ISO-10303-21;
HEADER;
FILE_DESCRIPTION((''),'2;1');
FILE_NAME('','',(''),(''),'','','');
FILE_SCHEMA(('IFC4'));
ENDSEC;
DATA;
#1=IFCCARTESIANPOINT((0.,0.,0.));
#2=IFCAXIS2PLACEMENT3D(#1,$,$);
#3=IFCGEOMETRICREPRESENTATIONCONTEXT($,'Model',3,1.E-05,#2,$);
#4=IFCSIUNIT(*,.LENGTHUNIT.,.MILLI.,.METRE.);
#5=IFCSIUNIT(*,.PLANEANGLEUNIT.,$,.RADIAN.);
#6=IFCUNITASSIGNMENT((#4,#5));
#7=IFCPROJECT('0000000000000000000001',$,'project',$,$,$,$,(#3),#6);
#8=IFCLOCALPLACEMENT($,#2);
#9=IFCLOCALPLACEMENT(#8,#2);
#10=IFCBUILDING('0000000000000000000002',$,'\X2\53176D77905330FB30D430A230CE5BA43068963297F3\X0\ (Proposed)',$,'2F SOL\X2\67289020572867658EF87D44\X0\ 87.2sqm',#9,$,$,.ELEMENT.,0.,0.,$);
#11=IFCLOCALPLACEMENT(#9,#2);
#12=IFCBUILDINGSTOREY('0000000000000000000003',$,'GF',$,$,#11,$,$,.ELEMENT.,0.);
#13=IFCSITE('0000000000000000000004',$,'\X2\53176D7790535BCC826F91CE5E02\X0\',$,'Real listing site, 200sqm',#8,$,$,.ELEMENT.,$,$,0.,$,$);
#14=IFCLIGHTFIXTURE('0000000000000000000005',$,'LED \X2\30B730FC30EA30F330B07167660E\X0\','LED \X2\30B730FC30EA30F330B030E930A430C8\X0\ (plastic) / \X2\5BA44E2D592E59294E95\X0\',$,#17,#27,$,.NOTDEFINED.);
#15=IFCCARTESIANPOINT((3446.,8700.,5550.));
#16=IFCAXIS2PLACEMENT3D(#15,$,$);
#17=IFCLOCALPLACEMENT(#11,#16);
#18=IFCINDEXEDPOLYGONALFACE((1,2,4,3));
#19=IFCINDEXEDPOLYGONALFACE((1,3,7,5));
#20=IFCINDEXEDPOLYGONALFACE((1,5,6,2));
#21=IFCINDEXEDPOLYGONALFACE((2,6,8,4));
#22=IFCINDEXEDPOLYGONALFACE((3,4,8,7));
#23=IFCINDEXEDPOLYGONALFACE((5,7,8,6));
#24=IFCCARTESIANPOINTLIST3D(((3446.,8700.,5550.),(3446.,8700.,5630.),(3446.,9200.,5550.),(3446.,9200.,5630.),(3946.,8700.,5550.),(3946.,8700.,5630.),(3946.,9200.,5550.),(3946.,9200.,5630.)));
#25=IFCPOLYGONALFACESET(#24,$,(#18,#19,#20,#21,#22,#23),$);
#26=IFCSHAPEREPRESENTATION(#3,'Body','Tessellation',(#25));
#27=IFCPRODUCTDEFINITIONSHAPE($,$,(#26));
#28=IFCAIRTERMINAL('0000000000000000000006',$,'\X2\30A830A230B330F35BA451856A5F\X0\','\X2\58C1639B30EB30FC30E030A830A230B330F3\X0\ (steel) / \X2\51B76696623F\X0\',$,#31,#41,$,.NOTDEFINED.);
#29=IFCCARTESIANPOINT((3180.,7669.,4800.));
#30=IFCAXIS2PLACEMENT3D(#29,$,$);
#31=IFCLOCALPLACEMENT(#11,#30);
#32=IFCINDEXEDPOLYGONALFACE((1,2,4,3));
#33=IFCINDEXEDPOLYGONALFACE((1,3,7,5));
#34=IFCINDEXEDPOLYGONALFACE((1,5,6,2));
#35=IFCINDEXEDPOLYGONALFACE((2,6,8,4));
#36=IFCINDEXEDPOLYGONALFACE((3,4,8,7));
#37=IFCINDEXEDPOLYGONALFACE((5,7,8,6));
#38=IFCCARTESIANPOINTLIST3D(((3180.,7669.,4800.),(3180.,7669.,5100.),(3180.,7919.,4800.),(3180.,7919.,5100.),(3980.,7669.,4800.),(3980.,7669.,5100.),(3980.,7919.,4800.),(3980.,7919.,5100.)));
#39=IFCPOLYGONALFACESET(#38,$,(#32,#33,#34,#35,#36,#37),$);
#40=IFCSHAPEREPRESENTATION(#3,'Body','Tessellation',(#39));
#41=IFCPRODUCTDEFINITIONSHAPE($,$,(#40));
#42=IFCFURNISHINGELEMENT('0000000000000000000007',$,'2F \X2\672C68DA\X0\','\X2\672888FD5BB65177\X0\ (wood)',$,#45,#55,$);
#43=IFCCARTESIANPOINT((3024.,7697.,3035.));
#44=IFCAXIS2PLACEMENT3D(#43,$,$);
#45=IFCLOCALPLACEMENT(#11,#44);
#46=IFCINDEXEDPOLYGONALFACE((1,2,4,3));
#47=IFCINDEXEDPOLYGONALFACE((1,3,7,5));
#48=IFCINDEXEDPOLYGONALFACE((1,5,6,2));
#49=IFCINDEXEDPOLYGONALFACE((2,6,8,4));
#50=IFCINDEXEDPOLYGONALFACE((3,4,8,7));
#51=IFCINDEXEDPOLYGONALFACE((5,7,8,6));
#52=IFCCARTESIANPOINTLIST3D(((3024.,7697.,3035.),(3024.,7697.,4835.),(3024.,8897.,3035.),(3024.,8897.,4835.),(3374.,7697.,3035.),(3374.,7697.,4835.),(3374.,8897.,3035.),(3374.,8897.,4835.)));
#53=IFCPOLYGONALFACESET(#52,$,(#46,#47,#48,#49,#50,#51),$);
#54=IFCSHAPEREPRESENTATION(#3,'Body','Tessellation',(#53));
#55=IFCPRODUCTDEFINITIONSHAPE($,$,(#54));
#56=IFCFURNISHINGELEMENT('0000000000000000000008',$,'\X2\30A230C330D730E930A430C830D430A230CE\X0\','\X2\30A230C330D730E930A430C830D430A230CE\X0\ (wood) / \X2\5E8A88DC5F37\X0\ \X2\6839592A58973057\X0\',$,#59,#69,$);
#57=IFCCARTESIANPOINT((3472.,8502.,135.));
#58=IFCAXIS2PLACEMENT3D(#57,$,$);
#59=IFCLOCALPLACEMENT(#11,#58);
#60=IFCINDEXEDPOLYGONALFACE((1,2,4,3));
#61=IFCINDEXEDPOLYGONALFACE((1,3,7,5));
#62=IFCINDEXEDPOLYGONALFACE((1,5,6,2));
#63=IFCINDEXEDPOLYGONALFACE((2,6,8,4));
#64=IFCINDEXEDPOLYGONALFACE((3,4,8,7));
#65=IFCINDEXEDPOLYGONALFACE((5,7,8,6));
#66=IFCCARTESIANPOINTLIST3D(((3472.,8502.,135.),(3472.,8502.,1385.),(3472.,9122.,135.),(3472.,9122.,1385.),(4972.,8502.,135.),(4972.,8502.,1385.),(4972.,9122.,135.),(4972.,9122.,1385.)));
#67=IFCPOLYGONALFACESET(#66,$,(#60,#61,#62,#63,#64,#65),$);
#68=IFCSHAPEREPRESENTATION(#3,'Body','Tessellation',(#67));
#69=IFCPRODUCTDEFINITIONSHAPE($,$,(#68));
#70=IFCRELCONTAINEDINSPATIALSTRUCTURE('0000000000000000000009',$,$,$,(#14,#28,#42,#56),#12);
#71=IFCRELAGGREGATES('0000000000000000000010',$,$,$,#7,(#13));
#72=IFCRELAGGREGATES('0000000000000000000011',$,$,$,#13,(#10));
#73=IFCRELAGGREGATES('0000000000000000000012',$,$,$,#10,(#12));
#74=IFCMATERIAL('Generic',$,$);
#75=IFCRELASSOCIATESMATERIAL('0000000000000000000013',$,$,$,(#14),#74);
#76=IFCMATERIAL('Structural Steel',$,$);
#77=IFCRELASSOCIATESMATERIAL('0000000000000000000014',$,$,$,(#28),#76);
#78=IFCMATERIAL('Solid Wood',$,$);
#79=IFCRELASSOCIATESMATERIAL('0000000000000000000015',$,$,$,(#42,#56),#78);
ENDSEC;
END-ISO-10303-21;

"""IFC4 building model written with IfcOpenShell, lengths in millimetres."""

from ifc_helpers import new_model, si_unit, frame, frame_2d, origin, place, context, project, spatial, rectangle, extrude, material, element, save


model = new_model("IFC4")

# Units and contexts
model_context = context("Model", 3, precision=1e-05, world=origin())
ifc_project = project(units=[si_unit("LENGTHUNIT", "METRE", prefix="MILLI"), si_unit("PLANEANGLEUNIT", "RADIAN")], contexts=[model_context])

# Site, building, storey
site_placement = place(None, origin())
site = spatial("IfcSite", under=ifc_project, at=site_placement, Name="北海道富良野市", ObjectType="Real listing site, 200sqm", CompositionType="ELEMENT", RefElevation=0.0)
building_placement = place(site_placement, origin())
building = spatial("IfcBuilding", under=site, at=building_placement, Name="北海道・ピアノ室と防音 (Proposed)", ObjectType="2F SOL木造在来軸組 87.2sqm", CompositionType="ELEMENT", ElevationOfRefHeight=0.0, ElevationOfTerrain=0.0)
storey_placement = place(building_placement, origin())
storey = spatial("IfcBuildingStorey", under=building, at=storey_placement, Name="GF", CompositionType="ELEMENT", Elevation=0.0)

# Shared definitions
ifc_material_1 = material(Name="Solid Wood")

# Shared definitions
ifc_material_2 = material(Name="Structural Steel")

# Shared definitions
ifc_material_3 = material(Name="Generic")

# Light fixture
light_fixture_1_placement = place(storey_placement, frame((3446.0, 8700.0, 5550.0)))
element("IfcLightFixture", 1, at=light_fixture_1_placement, inside=storey, material=ifc_material_3, Name="LED シーリング照明", Description="LED シーリングライト (plastic) / 室中央天井", PredefinedType="NOTDEFINED", context=model_context, shape_type="SweptSolid", body=[
    extrude(rectangle(XDim=500.0, YDim=500.0, at=frame_2d((250.0, 250.0))), frame((3446.0, 8700.0, 5550.0)), (0.0, 0.0, 1.0), 80.0),
])

# Air terminal
air_terminal_placement = place(storey_placement, frame((3180.0, 7669.0, 4800.0)))
element("IfcAirTerminal", 2, at=air_terminal_placement, inside=storey, material=ifc_material_2, Name="エアコン室内機", Description="壁掛ルームエアコン (steel) / 冷暖房", PredefinedType="NOTDEFINED", context=model_context, shape_type="SweptSolid", body=[
    extrude(rectangle(XDim=800.0, YDim=250.0, at=frame_2d((400.0, 125.0))), frame((3180.0, 7669.0, 4800.0)), (0.0, 0.0, 1.0), 300.0),
])

# Furnishing elements
furnishing_1_placement = place(storey_placement, frame((3024.0, 7697.0, 3035.0)))
element("IfcFurnishingElement", 3, at=furnishing_1_placement, inside=storey, material=ifc_material_1, Name="2F 本棚", Description="木製家具 (wood)", context=model_context, shape_type="SweptSolid", body=[
    extrude(rectangle(XDim=350.0, YDim=1200.0, at=frame_2d((175.0, 600.0))), frame((3024.0, 7697.0, 3035.0)), (0.0, 0.0, 1.0), 1800.0),
])
furnishing_2_placement = place(storey_placement, frame((3472.0, 8502.0, 135.0)))
element("IfcFurnishingElement", 4, at=furnishing_2_placement, inside=storey, material=ifc_material_1, Name="アップライトピアノ", Description="アップライトピアノ (wood) / 床補強 根太増し", context=model_context, shape_type="SweptSolid", body=[
    extrude(rectangle(XDim=1500.0, YDim=620.0, at=frame_2d((750.0, 310.0))), frame((3472.0, 8502.0, 135.0)), (0.0, 0.0, 1.0), 1250.0),
])

save(model, "model.ifc")
